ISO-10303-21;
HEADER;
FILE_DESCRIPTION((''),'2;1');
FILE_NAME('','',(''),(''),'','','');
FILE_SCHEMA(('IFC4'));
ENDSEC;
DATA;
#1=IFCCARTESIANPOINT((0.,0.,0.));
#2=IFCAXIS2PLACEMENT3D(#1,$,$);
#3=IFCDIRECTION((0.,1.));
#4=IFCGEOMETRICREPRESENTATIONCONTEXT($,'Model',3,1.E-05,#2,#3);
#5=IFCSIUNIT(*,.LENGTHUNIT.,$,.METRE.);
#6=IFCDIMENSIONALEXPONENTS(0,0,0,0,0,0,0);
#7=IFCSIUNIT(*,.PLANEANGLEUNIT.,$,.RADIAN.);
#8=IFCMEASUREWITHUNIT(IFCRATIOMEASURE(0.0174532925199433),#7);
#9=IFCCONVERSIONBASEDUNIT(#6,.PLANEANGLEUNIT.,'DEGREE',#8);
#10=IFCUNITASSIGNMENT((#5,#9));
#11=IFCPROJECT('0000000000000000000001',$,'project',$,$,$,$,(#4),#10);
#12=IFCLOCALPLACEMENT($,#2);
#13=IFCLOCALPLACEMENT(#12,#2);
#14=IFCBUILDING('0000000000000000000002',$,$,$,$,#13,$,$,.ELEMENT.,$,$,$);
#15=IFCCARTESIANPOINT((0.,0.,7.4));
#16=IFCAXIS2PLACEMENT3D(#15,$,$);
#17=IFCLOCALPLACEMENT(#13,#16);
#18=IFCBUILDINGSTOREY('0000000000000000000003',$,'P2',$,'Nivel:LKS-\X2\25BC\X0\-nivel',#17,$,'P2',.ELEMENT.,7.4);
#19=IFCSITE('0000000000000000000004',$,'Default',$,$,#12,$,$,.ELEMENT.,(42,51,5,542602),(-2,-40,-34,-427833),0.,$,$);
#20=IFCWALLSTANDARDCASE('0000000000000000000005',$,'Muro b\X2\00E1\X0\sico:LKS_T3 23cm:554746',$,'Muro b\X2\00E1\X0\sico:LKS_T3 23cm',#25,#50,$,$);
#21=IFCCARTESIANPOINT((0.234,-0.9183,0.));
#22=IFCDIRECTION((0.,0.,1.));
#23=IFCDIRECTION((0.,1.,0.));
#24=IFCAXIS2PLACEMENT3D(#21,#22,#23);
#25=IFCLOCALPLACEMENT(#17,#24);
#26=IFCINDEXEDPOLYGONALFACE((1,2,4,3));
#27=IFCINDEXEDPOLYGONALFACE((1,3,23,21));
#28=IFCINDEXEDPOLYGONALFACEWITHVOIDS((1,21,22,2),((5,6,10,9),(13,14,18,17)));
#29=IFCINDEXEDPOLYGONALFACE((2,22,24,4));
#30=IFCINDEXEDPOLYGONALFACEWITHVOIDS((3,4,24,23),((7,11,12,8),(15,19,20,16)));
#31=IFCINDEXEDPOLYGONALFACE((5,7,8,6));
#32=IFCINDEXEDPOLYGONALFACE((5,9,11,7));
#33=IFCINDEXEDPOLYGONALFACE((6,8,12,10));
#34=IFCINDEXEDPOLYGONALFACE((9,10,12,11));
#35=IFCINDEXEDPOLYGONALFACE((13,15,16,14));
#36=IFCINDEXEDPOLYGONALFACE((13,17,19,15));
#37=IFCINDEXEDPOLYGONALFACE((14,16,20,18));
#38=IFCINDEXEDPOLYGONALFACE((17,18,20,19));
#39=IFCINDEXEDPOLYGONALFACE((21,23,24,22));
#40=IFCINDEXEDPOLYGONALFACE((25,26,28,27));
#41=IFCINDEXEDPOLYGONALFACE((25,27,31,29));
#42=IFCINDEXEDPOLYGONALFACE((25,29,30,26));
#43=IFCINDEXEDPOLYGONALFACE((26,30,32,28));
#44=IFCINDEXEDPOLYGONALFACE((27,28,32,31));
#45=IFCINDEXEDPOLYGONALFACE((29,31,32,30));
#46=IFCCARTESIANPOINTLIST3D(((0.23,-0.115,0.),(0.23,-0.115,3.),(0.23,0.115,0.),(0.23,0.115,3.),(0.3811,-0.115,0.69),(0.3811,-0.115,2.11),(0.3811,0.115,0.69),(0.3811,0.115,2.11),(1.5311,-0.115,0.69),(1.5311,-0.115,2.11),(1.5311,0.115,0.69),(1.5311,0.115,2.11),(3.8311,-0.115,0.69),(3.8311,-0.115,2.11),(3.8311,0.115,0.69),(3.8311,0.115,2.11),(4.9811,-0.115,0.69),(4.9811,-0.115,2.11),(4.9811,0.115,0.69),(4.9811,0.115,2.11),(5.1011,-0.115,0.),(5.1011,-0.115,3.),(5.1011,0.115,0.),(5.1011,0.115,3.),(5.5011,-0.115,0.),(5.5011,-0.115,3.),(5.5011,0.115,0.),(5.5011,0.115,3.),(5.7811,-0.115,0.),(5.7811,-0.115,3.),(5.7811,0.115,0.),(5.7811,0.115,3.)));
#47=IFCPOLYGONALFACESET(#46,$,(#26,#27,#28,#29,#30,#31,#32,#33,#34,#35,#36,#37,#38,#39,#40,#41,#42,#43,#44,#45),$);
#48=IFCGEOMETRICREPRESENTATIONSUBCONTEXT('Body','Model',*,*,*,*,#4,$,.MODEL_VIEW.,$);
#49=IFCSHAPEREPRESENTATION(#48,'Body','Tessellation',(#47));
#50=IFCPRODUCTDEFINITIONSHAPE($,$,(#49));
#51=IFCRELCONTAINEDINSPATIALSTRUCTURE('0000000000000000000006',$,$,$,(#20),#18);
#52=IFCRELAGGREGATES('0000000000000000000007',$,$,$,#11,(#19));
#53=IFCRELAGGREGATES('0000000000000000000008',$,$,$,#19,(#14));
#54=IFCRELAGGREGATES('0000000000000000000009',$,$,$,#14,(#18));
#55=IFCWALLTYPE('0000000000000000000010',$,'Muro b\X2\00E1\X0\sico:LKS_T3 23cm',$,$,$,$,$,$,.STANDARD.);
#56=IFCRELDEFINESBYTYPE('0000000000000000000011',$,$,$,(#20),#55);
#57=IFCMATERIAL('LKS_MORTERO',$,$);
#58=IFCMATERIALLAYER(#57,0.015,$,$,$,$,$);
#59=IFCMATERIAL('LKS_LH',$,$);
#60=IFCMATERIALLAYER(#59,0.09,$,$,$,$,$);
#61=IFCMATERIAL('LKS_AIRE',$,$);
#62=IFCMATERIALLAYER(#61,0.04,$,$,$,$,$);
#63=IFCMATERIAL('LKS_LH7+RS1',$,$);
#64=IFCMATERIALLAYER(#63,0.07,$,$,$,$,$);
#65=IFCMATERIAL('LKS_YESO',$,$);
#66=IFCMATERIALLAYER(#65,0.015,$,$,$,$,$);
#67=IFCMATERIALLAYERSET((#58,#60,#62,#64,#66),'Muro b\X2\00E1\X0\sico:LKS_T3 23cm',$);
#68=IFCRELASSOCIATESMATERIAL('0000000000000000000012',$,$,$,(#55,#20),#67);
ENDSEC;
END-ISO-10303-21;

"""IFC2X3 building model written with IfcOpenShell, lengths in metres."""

from ifc_helpers import new_model, entity, si_unit, converted_unit, direction, frame, frame_2d, origin, place, context, subcontext, project, spatial, rectangle, extrude, material, layer, layer_set, layer_usage, type_object, element, save


model = new_model("IFC2X3")

# Units and contexts
model_context = context("Model", 3, precision=1e-05, world=origin(), true_north=direction((0.0, 1.0)))
body_context = subcontext(model_context, "Body", "Model", "MODEL_VIEW")
ifc_project = project(units=[si_unit("LENGTHUNIT", "METRE"), converted_unit("PLANEANGLEUNIT", "DEGREE", entity("IfcRatioMeasure", 0.0174532925199433), si_unit("PLANEANGLEUNIT", "RADIAN"), dimensions=[0, 0, 0, 0, 0, 0, 0])], contexts=[model_context])

# Site, building, storey
site_placement = place(None, origin())
site = spatial("IfcSite", under=ifc_project, at=site_placement, Name="Default", CompositionType="ELEMENT", RefLatitude=(42, 51, 5, 542602), RefLongitude=(-2, -40, -34, -427833), RefElevation=0.0)
building_placement = place(site_placement, origin())
building = spatial("IfcBuilding", under=site, at=building_placement, CompositionType="ELEMENT")
storey_placement = place(building_placement, frame((0.0, 0.0, 7.4)))
storey = spatial("IfcBuildingStorey", under=building, at=storey_placement, Name="P2", ObjectType="Nivel:LKS-▼-nivel", LongName="P2", CompositionType="ELEMENT", Elevation=7.4)

# Shared definitions
ifc_material_1 = material(Name="LKS_MORTERO")
ifc_material_2 = material(Name="LKS_LH")
ifc_material_3 = material(Name="LKS_AIRE")
ifc_material_4 = material(Name="LKS_YESO")

# Shared definitions
ifc_material_5 = material(Name="LKS_LH7+RS1")

# Shared definitions
ifc_layer_1 = layer(ifc_material_1, 0.015)
ifc_layer_2 = layer(ifc_material_2, 0.09)
ifc_layer_3 = layer(ifc_material_3, 0.04)
ifc_layer_4 = layer(ifc_material_5, 0.07)
ifc_layer_5 = layer(ifc_material_4, 0.015)
ifc_layer_set_1 = layer_set([ifc_layer_1, ifc_layer_2, ifc_layer_3, ifc_layer_4, ifc_layer_5], Name="Muro básico:LKS_T3 23cm")
wall_type_1 = type_object("IfcWallType", Name="Muro básico:LKS_T3 23cm", PredefinedType="STANDARD", material=ifc_layer_set_1)

# Wall, openings
ifc_layer_usage_1 = layer_usage(ifc_layer_set_1, "AXIS2", "POSITIVE", -0.115)
wall_1_placement = place(storey_placement, frame((0.234, -0.9183, 0.0), z_axis=(0.0, 0.0, 1.0), x_axis=(0.0, 1.0, 0.0)))
wall_1 = element("IfcWallStandardCase", 1, at=wall_1_placement, inside=storey, type_object=wall_type_1, material=ifc_layer_usage_1, Name="Muro básico:LKS_T3 23cm:554746", ObjectType="Muro básico:LKS_T3 23cm", context=body_context, shape_type="SweptSolid", body=[
    extrude(rectangle(XDim=5.5511, YDim=0.23, at=frame_2d((3.0056, 0.0), x_axis=(1.0, 0.0))), origin(), (0.0, 0.0, 1.0), 3.0),
])
opening_1_placement = place(storey_placement, frame((0.234, -0.9183, 0.0), z_axis=(0.0, 0.0, 1.0), x_axis=(0.0, 1.0, 0.0)))
element("IfcOpeningElement", 2, at=opening_1_placement, cuts=wall_1, ObjectType="Opening", context=body_context, shape_type="SweptSolid", body=[
    extrude(rectangle(XDim=3.0, YDim=0.23, at=frame_2d((0.3, 0.013), x_axis=(1.0, 0.0))), frame((5.1011, -0.013, 1.8), z_axis=(1.0, 0.0, 0.0), x_axis=(0.0, 0.0, -1.0)), (0.0, 0.0, 1.0), 0.4),
])
opening_2_placement = place(wall_1_placement, frame((4.9811, 0.115, 0.69)))
element("IfcOpeningElement", 3, at=opening_2_placement, cuts=wall_1, ObjectType="Opening", context=body_context, shape_type="SweptSolid", body=[
    extrude(rectangle(XDim=1.42, YDim=1.15, at=frame_2d((0.71, 0.575), x_axis=(1.0, 0.0))), frame((0.0, 0.0, 0.0), z_axis=(0.0, -1.0, 0.0), x_axis=(0.0, 0.0, 1.0)), (0.0, 0.0, 1.0), 0.23),
])
opening_3_placement = place(wall_1_placement, frame((1.5311, 0.115, 0.69)))
element("IfcOpeningElement", 4, at=opening_3_placement, cuts=wall_1, ObjectType="Opening", context=body_context, shape_type="SweptSolid", body=[
    extrude(rectangle(XDim=1.42, YDim=1.15, at=frame_2d((0.71, 0.575), x_axis=(1.0, 0.0))), frame((0.0, 0.0, 0.0), z_axis=(0.0, -1.0, 0.0), x_axis=(0.0, 0.0, 1.0)), (0.0, 0.0, 1.0), 0.23),
])

save(model, "model.ifc")
